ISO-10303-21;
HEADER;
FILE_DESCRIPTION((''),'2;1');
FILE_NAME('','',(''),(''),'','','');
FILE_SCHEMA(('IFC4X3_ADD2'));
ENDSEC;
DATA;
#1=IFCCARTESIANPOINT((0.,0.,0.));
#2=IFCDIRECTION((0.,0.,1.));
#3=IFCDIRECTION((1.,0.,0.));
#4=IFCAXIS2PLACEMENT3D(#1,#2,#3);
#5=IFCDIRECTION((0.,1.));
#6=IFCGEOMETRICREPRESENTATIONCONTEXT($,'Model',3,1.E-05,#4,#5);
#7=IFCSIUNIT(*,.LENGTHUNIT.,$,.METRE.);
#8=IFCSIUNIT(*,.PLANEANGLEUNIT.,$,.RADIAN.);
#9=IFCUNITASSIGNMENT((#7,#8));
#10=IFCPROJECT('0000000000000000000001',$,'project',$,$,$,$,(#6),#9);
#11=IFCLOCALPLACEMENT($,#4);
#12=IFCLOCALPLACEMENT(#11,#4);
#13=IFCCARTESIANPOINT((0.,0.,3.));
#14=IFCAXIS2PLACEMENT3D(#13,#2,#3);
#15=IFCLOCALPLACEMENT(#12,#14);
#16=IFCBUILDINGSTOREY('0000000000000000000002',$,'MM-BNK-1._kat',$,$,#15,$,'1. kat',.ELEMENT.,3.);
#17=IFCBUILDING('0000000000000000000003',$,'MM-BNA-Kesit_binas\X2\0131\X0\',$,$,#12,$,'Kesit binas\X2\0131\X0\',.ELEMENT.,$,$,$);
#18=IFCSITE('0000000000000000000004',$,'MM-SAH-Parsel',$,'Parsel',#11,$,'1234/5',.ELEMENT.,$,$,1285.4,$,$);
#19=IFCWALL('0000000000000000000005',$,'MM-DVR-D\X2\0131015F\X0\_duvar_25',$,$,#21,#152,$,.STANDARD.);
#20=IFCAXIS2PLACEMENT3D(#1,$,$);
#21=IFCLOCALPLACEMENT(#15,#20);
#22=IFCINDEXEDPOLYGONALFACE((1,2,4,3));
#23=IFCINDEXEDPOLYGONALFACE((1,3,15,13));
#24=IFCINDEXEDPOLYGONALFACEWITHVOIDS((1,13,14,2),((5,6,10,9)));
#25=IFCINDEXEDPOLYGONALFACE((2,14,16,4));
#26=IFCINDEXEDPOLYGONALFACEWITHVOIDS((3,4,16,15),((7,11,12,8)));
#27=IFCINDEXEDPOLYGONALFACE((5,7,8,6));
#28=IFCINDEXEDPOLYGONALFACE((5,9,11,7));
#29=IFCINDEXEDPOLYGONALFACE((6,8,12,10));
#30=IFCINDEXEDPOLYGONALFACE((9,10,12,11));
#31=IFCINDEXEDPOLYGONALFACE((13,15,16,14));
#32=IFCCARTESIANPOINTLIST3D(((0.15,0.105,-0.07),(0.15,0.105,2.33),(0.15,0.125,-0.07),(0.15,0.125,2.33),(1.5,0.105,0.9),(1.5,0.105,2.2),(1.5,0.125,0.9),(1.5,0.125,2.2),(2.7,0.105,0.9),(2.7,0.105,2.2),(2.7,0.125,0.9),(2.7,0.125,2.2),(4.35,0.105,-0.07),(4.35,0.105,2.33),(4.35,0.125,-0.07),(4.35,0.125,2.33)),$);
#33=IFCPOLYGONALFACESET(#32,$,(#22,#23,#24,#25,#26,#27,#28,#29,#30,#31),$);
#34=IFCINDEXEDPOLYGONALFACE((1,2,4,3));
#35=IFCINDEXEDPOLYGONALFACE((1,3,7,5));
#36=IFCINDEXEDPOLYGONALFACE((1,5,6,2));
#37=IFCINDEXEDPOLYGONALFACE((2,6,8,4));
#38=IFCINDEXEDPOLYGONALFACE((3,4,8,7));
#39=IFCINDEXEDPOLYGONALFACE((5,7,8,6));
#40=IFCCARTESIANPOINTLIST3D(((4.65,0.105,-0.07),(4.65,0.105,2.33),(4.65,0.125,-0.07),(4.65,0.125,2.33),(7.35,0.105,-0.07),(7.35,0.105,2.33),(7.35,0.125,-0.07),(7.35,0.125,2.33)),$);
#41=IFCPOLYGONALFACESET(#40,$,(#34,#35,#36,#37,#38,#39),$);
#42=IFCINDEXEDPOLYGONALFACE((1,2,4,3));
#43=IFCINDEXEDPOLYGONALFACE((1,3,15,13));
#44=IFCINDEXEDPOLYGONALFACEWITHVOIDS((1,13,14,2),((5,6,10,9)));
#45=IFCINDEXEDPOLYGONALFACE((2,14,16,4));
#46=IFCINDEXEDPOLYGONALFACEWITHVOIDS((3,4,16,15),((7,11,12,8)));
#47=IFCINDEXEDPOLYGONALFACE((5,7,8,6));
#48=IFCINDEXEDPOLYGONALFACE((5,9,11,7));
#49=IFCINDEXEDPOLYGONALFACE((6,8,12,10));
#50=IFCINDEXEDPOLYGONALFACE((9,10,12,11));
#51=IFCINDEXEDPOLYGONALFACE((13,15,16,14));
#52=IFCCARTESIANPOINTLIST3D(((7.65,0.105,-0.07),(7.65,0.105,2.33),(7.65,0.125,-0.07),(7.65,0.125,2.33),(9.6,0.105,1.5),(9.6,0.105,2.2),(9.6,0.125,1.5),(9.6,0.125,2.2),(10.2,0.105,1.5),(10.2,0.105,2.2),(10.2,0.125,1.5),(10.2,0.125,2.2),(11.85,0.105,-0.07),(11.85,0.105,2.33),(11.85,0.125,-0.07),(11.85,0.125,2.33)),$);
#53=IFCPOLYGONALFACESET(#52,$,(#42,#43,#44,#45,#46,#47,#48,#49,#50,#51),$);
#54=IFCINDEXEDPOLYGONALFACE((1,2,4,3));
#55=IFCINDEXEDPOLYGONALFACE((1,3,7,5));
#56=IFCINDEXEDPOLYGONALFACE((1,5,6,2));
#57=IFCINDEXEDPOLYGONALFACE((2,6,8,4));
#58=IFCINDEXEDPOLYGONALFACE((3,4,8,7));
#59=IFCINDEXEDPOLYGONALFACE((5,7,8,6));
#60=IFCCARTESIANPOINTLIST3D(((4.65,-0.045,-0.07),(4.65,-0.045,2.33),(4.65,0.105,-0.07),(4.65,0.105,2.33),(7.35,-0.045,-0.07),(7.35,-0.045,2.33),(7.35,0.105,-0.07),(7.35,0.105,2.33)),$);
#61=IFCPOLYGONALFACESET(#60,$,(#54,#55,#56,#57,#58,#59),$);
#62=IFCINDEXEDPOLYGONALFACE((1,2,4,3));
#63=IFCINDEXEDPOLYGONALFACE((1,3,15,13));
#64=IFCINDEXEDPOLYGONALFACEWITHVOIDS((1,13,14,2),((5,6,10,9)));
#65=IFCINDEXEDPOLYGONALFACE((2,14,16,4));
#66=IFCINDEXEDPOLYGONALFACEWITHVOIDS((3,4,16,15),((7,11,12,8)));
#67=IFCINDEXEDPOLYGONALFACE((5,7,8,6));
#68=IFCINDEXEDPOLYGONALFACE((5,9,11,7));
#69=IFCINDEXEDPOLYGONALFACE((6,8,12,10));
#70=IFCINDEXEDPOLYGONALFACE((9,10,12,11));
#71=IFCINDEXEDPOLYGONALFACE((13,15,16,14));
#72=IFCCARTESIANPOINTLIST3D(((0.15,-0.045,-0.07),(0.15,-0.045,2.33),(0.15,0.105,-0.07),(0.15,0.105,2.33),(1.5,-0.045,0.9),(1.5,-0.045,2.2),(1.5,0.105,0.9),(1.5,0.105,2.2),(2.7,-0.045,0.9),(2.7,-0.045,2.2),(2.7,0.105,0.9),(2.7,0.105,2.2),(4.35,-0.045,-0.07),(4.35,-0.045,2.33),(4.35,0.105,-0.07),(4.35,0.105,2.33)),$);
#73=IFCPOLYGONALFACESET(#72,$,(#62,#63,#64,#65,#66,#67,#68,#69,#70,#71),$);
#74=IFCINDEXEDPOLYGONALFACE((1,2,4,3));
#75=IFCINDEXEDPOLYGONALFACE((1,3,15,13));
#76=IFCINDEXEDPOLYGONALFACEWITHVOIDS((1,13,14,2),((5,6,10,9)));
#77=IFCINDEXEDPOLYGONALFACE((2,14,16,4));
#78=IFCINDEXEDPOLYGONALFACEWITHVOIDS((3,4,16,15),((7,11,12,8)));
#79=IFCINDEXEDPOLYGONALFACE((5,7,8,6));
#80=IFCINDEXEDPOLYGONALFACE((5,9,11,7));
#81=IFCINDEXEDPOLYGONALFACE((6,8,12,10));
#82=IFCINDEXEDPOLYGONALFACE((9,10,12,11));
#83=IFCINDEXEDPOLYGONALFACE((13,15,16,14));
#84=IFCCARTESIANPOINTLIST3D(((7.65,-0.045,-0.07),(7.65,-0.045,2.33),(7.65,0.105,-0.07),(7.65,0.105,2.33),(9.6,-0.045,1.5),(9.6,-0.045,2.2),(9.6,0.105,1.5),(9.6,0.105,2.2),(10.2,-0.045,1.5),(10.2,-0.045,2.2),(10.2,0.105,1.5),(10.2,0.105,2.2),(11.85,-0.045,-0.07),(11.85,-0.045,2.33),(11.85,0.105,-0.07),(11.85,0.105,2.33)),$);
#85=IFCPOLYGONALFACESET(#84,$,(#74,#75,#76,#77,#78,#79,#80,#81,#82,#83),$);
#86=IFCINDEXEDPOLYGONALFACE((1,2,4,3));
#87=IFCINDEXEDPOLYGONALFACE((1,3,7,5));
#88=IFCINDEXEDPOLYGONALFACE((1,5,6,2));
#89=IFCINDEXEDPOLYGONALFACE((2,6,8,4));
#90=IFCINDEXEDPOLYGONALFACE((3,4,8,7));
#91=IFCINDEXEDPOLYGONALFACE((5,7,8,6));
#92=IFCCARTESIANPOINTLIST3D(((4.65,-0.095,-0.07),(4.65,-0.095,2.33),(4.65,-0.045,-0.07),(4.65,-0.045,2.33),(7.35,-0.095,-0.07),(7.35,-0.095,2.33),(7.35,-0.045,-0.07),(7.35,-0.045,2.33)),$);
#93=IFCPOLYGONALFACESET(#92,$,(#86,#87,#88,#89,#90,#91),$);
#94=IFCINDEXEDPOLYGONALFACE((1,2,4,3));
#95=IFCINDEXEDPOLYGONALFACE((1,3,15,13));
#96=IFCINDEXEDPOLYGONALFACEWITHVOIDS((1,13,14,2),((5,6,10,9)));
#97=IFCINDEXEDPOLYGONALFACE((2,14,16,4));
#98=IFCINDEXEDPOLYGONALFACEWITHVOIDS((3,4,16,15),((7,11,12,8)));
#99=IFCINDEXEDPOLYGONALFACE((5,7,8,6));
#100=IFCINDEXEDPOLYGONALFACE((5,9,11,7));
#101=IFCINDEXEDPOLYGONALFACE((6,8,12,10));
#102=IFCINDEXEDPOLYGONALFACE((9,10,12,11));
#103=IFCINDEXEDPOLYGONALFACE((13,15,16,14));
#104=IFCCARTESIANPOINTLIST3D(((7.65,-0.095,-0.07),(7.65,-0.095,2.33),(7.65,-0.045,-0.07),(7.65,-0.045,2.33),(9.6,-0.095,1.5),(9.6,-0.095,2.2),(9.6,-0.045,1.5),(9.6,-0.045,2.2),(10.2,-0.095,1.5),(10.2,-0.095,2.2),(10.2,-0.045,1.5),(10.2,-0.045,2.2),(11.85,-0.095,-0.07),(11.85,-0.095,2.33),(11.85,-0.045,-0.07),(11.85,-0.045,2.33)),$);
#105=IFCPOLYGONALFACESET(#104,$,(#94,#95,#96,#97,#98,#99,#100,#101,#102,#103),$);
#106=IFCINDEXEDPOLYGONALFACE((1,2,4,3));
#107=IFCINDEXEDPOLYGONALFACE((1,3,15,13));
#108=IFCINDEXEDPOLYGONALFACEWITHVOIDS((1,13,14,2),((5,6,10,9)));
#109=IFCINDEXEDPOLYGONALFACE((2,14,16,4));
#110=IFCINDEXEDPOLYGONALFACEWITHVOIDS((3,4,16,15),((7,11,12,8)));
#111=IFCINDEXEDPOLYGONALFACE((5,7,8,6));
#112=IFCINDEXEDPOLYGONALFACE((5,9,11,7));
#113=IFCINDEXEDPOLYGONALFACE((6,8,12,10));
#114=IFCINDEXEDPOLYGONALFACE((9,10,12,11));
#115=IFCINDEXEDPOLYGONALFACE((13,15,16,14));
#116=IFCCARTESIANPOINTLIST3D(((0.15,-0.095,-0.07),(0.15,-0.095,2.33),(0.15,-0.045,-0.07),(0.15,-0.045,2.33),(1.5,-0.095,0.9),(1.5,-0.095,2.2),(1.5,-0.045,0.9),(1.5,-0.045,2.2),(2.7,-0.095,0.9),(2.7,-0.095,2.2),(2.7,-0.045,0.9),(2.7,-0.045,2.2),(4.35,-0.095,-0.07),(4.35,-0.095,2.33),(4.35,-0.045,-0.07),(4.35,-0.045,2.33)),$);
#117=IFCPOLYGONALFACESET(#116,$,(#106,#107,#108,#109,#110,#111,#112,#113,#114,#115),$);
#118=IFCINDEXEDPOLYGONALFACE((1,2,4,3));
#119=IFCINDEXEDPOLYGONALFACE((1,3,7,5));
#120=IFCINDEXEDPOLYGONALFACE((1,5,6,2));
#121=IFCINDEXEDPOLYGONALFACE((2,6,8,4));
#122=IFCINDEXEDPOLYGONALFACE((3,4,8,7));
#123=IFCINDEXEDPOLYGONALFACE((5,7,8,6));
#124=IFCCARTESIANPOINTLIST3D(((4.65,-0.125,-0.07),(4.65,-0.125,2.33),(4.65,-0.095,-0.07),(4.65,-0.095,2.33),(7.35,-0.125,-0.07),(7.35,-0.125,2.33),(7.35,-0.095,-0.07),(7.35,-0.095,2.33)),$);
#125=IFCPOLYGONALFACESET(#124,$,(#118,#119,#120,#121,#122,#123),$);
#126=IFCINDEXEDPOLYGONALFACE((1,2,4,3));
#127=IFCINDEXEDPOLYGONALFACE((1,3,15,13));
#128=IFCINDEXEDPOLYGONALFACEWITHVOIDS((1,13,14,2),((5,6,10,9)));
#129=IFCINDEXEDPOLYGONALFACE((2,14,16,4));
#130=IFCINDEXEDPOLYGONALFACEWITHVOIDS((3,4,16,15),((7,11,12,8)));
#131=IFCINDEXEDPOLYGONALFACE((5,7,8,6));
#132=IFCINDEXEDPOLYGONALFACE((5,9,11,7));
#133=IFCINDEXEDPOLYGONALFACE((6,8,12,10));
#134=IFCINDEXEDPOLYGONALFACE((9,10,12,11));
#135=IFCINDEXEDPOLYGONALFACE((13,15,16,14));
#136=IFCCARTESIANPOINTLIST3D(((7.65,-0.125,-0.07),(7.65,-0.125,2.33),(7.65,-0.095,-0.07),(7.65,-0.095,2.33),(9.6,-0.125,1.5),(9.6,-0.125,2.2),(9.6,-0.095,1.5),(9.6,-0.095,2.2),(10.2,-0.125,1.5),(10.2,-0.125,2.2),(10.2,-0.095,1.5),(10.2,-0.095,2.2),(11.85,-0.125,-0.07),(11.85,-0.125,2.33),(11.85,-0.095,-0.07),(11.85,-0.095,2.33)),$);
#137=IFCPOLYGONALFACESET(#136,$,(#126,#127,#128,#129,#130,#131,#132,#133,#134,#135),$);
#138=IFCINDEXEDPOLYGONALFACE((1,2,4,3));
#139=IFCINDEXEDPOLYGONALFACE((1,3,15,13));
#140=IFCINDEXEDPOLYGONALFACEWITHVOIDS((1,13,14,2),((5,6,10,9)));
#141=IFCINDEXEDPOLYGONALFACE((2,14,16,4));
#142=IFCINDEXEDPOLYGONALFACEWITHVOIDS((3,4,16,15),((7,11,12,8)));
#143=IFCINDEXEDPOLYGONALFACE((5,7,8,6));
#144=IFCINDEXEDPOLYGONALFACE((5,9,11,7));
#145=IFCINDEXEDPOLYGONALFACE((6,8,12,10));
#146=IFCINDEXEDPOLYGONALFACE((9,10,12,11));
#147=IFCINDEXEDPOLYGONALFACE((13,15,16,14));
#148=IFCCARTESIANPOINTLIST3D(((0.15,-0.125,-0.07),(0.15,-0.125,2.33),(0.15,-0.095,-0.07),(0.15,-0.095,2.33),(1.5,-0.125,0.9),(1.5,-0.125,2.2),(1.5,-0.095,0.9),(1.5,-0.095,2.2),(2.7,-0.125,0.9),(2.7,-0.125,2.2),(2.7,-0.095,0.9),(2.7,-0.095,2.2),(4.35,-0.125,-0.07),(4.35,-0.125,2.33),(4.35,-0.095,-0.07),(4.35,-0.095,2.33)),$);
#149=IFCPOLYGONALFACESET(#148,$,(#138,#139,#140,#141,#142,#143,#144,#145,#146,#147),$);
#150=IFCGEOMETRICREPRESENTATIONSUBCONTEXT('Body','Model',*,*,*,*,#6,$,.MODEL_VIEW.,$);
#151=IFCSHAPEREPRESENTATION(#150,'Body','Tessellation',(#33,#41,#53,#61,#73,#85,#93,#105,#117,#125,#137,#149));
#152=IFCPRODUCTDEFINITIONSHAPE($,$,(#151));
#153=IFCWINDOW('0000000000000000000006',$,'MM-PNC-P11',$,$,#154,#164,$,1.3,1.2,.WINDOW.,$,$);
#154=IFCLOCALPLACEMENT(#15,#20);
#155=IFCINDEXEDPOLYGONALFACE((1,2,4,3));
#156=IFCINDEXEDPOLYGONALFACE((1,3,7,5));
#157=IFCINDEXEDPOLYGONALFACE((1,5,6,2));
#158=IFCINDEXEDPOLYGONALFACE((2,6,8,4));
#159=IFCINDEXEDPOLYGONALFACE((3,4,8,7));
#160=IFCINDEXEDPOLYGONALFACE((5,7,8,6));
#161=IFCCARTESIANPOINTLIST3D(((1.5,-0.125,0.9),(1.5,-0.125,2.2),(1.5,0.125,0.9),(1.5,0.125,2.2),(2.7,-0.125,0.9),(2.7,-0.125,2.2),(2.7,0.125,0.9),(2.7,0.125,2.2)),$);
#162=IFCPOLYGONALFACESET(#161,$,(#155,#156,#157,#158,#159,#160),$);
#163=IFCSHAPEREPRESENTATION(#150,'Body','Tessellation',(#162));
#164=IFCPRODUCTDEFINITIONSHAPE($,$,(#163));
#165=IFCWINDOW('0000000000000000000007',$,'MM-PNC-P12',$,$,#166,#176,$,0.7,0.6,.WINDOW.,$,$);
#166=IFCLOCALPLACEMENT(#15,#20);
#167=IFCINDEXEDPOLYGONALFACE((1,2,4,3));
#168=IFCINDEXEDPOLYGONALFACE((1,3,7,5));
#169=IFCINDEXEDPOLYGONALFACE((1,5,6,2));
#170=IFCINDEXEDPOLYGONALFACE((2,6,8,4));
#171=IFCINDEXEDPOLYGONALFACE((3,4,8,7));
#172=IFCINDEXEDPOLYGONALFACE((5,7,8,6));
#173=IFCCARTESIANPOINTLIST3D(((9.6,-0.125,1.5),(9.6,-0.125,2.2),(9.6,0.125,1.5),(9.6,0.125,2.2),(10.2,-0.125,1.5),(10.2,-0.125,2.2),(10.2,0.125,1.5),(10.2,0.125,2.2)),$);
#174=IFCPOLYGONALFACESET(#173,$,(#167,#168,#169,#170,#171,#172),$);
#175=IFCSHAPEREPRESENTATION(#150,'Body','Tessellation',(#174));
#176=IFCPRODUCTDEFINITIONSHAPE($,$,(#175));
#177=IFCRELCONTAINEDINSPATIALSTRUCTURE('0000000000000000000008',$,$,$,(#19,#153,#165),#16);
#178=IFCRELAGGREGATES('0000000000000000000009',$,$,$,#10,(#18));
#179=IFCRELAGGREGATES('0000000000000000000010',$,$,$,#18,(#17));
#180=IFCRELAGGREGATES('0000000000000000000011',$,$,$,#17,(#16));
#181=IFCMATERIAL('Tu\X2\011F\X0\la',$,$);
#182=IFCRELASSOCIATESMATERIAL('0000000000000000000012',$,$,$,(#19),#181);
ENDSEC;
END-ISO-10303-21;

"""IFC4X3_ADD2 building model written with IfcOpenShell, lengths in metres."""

from ifc_helpers import new_model, si_unit, direction, frame, origin_with_axes, place, context, subcontext, project, spatial, polyline, outline, extrude, material, element, fill, save


model = new_model("IFC4X3_ADD2")

# Units and contexts
model_context = context("Model", 3, precision=1e-05, world=origin_with_axes(), true_north=direction((0.0, 1.0)))
body_context = subcontext(model_context, "Body", "Model", "MODEL_VIEW")
ifc_project = project(units=[si_unit("LENGTHUNIT", "METRE"), si_unit("PLANEANGLEUNIT", "RADIAN")], contexts=[model_context])

# Site, building, storey
site_placement = place(None, origin_with_axes())
site = spatial("IfcSite", under=ifc_project, at=site_placement, Name="MM-SAH-Parsel", ObjectType="Parsel", LongName="1234/5", CompositionType="ELEMENT", RefElevation=1285.4)
building_placement = place(site_placement, origin_with_axes())
building = spatial("IfcBuilding", under=site, at=building_placement, Name="MM-BNA-Kesit_binası", LongName="Kesit binası", CompositionType="ELEMENT")
storey_placement = place(building_placement, frame((0.0, 0.0, 3.0), z_axis=(0.0, 0.0, 1.0), x_axis=(1.0, 0.0, 0.0)))
storey = spatial("IfcBuildingStorey", under=building, at=storey_placement, Name="MM-BNK-1._kat", LongName="1. kat", CompositionType="ELEMENT", Elevation=3.0)

# Wall, openings, windows
ifc_material_1 = material(Name="Tuğla")
wall_1_placement = place(storey_placement, origin_with_axes())
wall_1 = element("IfcWall", 1, at=wall_1_placement, inside=storey, material=ifc_material_1, Name="MM-DVR-Dış_duvar_25", PredefinedType="STANDARD", context=body_context, shape_type="SweptSolid", body=[
    extrude(outline(polyline([(0.15, 0.105), (4.35, 0.105), (4.35, 0.125), (0.15, 0.125), (0.15, 0.105)])), frame((0.0, 0.0, -0.07)), (0.0, 0.0, 1.0), 2.4),
    extrude(outline(polyline([(4.65, 0.105), (7.35, 0.105), (7.35, 0.125), (4.65, 0.125), (4.65, 0.105)])), frame((0.0, 0.0, -0.07)), (0.0, 0.0, 1.0), 2.4),
    extrude(outline(polyline([(7.65, 0.105), (11.85, 0.105), (11.85, 0.125), (7.65, 0.125), (7.65, 0.105)])), frame((0.0, 0.0, -0.07)), (0.0, 0.0, 1.0), 2.4),
    extrude(outline(polyline([(4.65, -0.045), (7.35, -0.045), (7.35, 0.105), (4.65, 0.105), (4.65, -0.045)])), frame((0.0, 0.0, -0.07)), (0.0, 0.0, 1.0), 2.4),
    extrude(outline(polyline([(0.15, -0.045), (4.35, -0.045), (4.35, 0.105), (0.15, 0.105), (0.15, -0.045)])), frame((0.0, 0.0, -0.07)), (0.0, 0.0, 1.0), 2.4),
    extrude(outline(polyline([(7.65, -0.045), (11.85, -0.045), (11.85, 0.105), (7.65, 0.105), (7.65, -0.045)])), frame((0.0, 0.0, -0.07)), (0.0, 0.0, 1.0), 2.4),
    extrude(outline(polyline([(4.65, -0.095), (7.35, -0.095), (7.35, -0.045), (4.65, -0.045), (4.65, -0.095)])), frame((0.0, 0.0, -0.07)), (0.0, 0.0, 1.0), 2.4),
    extrude(outline(polyline([(7.65, -0.095), (11.85, -0.095), (11.85, -0.045), (7.65, -0.045), (7.65, -0.095)])), frame((0.0, 0.0, -0.07)), (0.0, 0.0, 1.0), 2.4),
    extrude(outline(polyline([(0.15, -0.095), (4.35, -0.095), (4.35, -0.045), (0.15, -0.045), (0.15, -0.095)])), frame((0.0, 0.0, -0.07)), (0.0, 0.0, 1.0), 2.4),
    extrude(outline(polyline([(4.65, -0.125), (7.35, -0.125), (7.35, -0.095), (4.65, -0.095), (4.65, -0.125)])), frame((0.0, 0.0, -0.07)), (0.0, 0.0, 1.0), 2.4),
    extrude(outline(polyline([(7.65, -0.125), (11.85, -0.125), (11.85, -0.095), (7.65, -0.095), (7.65, -0.125)])), frame((0.0, 0.0, -0.07)), (0.0, 0.0, 1.0), 2.4),
    extrude(outline(polyline([(0.15, -0.125), (4.35, -0.125), (4.35, -0.095), (0.15, -0.095), (0.15, -0.125)])), frame((0.0, 0.0, -0.07)), (0.0, 0.0, 1.0), 2.4),
])
opening_1_placement = place(storey_placement, origin_with_axes())
opening_1 = element("IfcOpeningElement", 2, at=opening_1_placement, cuts=wall_1, PredefinedType="OPENING", context=body_context, shape_type="SweptSolid", body=[
    extrude(outline(polyline([(1.5, 0.125), (2.7, 0.125), (2.7, -0.125), (1.5, -0.125), (1.5, 0.125)])), frame((0.0, 0.0, 0.9)), (0.0, 0.0, 1.0), 1.3),
])
opening_2_placement = place(storey_placement, origin_with_axes())
opening_2 = element("IfcOpeningElement", 3, at=opening_2_placement, cuts=wall_1, PredefinedType="OPENING", context=body_context, shape_type="SweptSolid", body=[
    extrude(outline(polyline([(9.6, 0.125), (10.2, 0.125), (10.2, -0.125), (9.6, -0.125), (9.6, 0.125)])), frame((0.0, 0.0, 1.5)), (0.0, 0.0, 1.0), 0.7),
])
window_1_placement = place(storey_placement, origin_with_axes())
window_1 = element("IfcWindow", 4, at=window_1_placement, inside=storey, Name="MM-PNC-P11", OverallHeight=1.3, OverallWidth=1.2, PredefinedType="WINDOW", context=body_context, shape_type="SweptSolid", body=[
    extrude(outline(polyline([(1.5, 0.125), (2.7, 0.125), (2.7, -0.125), (1.5, -0.125), (1.5, 0.125)])), frame((0.0, 0.0, 0.9)), (0.0, 0.0, 1.0), 1.3),
])
fill(opening_1, window_1)
window_2_placement = place(storey_placement, origin_with_axes())
window_2 = element("IfcWindow", 5, at=window_2_placement, inside=storey, Name="MM-PNC-P12", OverallHeight=0.7, OverallWidth=0.6, PredefinedType="WINDOW", context=body_context, shape_type="SweptSolid", body=[
    extrude(outline(polyline([(9.6, 0.125), (10.2, 0.125), (10.2, -0.125), (9.6, -0.125), (9.6, 0.125)])), frame((0.0, 0.0, 1.5)), (0.0, 0.0, 1.0), 0.7),
])
fill(opening_2, window_2)

save(model, "model.ifc")
